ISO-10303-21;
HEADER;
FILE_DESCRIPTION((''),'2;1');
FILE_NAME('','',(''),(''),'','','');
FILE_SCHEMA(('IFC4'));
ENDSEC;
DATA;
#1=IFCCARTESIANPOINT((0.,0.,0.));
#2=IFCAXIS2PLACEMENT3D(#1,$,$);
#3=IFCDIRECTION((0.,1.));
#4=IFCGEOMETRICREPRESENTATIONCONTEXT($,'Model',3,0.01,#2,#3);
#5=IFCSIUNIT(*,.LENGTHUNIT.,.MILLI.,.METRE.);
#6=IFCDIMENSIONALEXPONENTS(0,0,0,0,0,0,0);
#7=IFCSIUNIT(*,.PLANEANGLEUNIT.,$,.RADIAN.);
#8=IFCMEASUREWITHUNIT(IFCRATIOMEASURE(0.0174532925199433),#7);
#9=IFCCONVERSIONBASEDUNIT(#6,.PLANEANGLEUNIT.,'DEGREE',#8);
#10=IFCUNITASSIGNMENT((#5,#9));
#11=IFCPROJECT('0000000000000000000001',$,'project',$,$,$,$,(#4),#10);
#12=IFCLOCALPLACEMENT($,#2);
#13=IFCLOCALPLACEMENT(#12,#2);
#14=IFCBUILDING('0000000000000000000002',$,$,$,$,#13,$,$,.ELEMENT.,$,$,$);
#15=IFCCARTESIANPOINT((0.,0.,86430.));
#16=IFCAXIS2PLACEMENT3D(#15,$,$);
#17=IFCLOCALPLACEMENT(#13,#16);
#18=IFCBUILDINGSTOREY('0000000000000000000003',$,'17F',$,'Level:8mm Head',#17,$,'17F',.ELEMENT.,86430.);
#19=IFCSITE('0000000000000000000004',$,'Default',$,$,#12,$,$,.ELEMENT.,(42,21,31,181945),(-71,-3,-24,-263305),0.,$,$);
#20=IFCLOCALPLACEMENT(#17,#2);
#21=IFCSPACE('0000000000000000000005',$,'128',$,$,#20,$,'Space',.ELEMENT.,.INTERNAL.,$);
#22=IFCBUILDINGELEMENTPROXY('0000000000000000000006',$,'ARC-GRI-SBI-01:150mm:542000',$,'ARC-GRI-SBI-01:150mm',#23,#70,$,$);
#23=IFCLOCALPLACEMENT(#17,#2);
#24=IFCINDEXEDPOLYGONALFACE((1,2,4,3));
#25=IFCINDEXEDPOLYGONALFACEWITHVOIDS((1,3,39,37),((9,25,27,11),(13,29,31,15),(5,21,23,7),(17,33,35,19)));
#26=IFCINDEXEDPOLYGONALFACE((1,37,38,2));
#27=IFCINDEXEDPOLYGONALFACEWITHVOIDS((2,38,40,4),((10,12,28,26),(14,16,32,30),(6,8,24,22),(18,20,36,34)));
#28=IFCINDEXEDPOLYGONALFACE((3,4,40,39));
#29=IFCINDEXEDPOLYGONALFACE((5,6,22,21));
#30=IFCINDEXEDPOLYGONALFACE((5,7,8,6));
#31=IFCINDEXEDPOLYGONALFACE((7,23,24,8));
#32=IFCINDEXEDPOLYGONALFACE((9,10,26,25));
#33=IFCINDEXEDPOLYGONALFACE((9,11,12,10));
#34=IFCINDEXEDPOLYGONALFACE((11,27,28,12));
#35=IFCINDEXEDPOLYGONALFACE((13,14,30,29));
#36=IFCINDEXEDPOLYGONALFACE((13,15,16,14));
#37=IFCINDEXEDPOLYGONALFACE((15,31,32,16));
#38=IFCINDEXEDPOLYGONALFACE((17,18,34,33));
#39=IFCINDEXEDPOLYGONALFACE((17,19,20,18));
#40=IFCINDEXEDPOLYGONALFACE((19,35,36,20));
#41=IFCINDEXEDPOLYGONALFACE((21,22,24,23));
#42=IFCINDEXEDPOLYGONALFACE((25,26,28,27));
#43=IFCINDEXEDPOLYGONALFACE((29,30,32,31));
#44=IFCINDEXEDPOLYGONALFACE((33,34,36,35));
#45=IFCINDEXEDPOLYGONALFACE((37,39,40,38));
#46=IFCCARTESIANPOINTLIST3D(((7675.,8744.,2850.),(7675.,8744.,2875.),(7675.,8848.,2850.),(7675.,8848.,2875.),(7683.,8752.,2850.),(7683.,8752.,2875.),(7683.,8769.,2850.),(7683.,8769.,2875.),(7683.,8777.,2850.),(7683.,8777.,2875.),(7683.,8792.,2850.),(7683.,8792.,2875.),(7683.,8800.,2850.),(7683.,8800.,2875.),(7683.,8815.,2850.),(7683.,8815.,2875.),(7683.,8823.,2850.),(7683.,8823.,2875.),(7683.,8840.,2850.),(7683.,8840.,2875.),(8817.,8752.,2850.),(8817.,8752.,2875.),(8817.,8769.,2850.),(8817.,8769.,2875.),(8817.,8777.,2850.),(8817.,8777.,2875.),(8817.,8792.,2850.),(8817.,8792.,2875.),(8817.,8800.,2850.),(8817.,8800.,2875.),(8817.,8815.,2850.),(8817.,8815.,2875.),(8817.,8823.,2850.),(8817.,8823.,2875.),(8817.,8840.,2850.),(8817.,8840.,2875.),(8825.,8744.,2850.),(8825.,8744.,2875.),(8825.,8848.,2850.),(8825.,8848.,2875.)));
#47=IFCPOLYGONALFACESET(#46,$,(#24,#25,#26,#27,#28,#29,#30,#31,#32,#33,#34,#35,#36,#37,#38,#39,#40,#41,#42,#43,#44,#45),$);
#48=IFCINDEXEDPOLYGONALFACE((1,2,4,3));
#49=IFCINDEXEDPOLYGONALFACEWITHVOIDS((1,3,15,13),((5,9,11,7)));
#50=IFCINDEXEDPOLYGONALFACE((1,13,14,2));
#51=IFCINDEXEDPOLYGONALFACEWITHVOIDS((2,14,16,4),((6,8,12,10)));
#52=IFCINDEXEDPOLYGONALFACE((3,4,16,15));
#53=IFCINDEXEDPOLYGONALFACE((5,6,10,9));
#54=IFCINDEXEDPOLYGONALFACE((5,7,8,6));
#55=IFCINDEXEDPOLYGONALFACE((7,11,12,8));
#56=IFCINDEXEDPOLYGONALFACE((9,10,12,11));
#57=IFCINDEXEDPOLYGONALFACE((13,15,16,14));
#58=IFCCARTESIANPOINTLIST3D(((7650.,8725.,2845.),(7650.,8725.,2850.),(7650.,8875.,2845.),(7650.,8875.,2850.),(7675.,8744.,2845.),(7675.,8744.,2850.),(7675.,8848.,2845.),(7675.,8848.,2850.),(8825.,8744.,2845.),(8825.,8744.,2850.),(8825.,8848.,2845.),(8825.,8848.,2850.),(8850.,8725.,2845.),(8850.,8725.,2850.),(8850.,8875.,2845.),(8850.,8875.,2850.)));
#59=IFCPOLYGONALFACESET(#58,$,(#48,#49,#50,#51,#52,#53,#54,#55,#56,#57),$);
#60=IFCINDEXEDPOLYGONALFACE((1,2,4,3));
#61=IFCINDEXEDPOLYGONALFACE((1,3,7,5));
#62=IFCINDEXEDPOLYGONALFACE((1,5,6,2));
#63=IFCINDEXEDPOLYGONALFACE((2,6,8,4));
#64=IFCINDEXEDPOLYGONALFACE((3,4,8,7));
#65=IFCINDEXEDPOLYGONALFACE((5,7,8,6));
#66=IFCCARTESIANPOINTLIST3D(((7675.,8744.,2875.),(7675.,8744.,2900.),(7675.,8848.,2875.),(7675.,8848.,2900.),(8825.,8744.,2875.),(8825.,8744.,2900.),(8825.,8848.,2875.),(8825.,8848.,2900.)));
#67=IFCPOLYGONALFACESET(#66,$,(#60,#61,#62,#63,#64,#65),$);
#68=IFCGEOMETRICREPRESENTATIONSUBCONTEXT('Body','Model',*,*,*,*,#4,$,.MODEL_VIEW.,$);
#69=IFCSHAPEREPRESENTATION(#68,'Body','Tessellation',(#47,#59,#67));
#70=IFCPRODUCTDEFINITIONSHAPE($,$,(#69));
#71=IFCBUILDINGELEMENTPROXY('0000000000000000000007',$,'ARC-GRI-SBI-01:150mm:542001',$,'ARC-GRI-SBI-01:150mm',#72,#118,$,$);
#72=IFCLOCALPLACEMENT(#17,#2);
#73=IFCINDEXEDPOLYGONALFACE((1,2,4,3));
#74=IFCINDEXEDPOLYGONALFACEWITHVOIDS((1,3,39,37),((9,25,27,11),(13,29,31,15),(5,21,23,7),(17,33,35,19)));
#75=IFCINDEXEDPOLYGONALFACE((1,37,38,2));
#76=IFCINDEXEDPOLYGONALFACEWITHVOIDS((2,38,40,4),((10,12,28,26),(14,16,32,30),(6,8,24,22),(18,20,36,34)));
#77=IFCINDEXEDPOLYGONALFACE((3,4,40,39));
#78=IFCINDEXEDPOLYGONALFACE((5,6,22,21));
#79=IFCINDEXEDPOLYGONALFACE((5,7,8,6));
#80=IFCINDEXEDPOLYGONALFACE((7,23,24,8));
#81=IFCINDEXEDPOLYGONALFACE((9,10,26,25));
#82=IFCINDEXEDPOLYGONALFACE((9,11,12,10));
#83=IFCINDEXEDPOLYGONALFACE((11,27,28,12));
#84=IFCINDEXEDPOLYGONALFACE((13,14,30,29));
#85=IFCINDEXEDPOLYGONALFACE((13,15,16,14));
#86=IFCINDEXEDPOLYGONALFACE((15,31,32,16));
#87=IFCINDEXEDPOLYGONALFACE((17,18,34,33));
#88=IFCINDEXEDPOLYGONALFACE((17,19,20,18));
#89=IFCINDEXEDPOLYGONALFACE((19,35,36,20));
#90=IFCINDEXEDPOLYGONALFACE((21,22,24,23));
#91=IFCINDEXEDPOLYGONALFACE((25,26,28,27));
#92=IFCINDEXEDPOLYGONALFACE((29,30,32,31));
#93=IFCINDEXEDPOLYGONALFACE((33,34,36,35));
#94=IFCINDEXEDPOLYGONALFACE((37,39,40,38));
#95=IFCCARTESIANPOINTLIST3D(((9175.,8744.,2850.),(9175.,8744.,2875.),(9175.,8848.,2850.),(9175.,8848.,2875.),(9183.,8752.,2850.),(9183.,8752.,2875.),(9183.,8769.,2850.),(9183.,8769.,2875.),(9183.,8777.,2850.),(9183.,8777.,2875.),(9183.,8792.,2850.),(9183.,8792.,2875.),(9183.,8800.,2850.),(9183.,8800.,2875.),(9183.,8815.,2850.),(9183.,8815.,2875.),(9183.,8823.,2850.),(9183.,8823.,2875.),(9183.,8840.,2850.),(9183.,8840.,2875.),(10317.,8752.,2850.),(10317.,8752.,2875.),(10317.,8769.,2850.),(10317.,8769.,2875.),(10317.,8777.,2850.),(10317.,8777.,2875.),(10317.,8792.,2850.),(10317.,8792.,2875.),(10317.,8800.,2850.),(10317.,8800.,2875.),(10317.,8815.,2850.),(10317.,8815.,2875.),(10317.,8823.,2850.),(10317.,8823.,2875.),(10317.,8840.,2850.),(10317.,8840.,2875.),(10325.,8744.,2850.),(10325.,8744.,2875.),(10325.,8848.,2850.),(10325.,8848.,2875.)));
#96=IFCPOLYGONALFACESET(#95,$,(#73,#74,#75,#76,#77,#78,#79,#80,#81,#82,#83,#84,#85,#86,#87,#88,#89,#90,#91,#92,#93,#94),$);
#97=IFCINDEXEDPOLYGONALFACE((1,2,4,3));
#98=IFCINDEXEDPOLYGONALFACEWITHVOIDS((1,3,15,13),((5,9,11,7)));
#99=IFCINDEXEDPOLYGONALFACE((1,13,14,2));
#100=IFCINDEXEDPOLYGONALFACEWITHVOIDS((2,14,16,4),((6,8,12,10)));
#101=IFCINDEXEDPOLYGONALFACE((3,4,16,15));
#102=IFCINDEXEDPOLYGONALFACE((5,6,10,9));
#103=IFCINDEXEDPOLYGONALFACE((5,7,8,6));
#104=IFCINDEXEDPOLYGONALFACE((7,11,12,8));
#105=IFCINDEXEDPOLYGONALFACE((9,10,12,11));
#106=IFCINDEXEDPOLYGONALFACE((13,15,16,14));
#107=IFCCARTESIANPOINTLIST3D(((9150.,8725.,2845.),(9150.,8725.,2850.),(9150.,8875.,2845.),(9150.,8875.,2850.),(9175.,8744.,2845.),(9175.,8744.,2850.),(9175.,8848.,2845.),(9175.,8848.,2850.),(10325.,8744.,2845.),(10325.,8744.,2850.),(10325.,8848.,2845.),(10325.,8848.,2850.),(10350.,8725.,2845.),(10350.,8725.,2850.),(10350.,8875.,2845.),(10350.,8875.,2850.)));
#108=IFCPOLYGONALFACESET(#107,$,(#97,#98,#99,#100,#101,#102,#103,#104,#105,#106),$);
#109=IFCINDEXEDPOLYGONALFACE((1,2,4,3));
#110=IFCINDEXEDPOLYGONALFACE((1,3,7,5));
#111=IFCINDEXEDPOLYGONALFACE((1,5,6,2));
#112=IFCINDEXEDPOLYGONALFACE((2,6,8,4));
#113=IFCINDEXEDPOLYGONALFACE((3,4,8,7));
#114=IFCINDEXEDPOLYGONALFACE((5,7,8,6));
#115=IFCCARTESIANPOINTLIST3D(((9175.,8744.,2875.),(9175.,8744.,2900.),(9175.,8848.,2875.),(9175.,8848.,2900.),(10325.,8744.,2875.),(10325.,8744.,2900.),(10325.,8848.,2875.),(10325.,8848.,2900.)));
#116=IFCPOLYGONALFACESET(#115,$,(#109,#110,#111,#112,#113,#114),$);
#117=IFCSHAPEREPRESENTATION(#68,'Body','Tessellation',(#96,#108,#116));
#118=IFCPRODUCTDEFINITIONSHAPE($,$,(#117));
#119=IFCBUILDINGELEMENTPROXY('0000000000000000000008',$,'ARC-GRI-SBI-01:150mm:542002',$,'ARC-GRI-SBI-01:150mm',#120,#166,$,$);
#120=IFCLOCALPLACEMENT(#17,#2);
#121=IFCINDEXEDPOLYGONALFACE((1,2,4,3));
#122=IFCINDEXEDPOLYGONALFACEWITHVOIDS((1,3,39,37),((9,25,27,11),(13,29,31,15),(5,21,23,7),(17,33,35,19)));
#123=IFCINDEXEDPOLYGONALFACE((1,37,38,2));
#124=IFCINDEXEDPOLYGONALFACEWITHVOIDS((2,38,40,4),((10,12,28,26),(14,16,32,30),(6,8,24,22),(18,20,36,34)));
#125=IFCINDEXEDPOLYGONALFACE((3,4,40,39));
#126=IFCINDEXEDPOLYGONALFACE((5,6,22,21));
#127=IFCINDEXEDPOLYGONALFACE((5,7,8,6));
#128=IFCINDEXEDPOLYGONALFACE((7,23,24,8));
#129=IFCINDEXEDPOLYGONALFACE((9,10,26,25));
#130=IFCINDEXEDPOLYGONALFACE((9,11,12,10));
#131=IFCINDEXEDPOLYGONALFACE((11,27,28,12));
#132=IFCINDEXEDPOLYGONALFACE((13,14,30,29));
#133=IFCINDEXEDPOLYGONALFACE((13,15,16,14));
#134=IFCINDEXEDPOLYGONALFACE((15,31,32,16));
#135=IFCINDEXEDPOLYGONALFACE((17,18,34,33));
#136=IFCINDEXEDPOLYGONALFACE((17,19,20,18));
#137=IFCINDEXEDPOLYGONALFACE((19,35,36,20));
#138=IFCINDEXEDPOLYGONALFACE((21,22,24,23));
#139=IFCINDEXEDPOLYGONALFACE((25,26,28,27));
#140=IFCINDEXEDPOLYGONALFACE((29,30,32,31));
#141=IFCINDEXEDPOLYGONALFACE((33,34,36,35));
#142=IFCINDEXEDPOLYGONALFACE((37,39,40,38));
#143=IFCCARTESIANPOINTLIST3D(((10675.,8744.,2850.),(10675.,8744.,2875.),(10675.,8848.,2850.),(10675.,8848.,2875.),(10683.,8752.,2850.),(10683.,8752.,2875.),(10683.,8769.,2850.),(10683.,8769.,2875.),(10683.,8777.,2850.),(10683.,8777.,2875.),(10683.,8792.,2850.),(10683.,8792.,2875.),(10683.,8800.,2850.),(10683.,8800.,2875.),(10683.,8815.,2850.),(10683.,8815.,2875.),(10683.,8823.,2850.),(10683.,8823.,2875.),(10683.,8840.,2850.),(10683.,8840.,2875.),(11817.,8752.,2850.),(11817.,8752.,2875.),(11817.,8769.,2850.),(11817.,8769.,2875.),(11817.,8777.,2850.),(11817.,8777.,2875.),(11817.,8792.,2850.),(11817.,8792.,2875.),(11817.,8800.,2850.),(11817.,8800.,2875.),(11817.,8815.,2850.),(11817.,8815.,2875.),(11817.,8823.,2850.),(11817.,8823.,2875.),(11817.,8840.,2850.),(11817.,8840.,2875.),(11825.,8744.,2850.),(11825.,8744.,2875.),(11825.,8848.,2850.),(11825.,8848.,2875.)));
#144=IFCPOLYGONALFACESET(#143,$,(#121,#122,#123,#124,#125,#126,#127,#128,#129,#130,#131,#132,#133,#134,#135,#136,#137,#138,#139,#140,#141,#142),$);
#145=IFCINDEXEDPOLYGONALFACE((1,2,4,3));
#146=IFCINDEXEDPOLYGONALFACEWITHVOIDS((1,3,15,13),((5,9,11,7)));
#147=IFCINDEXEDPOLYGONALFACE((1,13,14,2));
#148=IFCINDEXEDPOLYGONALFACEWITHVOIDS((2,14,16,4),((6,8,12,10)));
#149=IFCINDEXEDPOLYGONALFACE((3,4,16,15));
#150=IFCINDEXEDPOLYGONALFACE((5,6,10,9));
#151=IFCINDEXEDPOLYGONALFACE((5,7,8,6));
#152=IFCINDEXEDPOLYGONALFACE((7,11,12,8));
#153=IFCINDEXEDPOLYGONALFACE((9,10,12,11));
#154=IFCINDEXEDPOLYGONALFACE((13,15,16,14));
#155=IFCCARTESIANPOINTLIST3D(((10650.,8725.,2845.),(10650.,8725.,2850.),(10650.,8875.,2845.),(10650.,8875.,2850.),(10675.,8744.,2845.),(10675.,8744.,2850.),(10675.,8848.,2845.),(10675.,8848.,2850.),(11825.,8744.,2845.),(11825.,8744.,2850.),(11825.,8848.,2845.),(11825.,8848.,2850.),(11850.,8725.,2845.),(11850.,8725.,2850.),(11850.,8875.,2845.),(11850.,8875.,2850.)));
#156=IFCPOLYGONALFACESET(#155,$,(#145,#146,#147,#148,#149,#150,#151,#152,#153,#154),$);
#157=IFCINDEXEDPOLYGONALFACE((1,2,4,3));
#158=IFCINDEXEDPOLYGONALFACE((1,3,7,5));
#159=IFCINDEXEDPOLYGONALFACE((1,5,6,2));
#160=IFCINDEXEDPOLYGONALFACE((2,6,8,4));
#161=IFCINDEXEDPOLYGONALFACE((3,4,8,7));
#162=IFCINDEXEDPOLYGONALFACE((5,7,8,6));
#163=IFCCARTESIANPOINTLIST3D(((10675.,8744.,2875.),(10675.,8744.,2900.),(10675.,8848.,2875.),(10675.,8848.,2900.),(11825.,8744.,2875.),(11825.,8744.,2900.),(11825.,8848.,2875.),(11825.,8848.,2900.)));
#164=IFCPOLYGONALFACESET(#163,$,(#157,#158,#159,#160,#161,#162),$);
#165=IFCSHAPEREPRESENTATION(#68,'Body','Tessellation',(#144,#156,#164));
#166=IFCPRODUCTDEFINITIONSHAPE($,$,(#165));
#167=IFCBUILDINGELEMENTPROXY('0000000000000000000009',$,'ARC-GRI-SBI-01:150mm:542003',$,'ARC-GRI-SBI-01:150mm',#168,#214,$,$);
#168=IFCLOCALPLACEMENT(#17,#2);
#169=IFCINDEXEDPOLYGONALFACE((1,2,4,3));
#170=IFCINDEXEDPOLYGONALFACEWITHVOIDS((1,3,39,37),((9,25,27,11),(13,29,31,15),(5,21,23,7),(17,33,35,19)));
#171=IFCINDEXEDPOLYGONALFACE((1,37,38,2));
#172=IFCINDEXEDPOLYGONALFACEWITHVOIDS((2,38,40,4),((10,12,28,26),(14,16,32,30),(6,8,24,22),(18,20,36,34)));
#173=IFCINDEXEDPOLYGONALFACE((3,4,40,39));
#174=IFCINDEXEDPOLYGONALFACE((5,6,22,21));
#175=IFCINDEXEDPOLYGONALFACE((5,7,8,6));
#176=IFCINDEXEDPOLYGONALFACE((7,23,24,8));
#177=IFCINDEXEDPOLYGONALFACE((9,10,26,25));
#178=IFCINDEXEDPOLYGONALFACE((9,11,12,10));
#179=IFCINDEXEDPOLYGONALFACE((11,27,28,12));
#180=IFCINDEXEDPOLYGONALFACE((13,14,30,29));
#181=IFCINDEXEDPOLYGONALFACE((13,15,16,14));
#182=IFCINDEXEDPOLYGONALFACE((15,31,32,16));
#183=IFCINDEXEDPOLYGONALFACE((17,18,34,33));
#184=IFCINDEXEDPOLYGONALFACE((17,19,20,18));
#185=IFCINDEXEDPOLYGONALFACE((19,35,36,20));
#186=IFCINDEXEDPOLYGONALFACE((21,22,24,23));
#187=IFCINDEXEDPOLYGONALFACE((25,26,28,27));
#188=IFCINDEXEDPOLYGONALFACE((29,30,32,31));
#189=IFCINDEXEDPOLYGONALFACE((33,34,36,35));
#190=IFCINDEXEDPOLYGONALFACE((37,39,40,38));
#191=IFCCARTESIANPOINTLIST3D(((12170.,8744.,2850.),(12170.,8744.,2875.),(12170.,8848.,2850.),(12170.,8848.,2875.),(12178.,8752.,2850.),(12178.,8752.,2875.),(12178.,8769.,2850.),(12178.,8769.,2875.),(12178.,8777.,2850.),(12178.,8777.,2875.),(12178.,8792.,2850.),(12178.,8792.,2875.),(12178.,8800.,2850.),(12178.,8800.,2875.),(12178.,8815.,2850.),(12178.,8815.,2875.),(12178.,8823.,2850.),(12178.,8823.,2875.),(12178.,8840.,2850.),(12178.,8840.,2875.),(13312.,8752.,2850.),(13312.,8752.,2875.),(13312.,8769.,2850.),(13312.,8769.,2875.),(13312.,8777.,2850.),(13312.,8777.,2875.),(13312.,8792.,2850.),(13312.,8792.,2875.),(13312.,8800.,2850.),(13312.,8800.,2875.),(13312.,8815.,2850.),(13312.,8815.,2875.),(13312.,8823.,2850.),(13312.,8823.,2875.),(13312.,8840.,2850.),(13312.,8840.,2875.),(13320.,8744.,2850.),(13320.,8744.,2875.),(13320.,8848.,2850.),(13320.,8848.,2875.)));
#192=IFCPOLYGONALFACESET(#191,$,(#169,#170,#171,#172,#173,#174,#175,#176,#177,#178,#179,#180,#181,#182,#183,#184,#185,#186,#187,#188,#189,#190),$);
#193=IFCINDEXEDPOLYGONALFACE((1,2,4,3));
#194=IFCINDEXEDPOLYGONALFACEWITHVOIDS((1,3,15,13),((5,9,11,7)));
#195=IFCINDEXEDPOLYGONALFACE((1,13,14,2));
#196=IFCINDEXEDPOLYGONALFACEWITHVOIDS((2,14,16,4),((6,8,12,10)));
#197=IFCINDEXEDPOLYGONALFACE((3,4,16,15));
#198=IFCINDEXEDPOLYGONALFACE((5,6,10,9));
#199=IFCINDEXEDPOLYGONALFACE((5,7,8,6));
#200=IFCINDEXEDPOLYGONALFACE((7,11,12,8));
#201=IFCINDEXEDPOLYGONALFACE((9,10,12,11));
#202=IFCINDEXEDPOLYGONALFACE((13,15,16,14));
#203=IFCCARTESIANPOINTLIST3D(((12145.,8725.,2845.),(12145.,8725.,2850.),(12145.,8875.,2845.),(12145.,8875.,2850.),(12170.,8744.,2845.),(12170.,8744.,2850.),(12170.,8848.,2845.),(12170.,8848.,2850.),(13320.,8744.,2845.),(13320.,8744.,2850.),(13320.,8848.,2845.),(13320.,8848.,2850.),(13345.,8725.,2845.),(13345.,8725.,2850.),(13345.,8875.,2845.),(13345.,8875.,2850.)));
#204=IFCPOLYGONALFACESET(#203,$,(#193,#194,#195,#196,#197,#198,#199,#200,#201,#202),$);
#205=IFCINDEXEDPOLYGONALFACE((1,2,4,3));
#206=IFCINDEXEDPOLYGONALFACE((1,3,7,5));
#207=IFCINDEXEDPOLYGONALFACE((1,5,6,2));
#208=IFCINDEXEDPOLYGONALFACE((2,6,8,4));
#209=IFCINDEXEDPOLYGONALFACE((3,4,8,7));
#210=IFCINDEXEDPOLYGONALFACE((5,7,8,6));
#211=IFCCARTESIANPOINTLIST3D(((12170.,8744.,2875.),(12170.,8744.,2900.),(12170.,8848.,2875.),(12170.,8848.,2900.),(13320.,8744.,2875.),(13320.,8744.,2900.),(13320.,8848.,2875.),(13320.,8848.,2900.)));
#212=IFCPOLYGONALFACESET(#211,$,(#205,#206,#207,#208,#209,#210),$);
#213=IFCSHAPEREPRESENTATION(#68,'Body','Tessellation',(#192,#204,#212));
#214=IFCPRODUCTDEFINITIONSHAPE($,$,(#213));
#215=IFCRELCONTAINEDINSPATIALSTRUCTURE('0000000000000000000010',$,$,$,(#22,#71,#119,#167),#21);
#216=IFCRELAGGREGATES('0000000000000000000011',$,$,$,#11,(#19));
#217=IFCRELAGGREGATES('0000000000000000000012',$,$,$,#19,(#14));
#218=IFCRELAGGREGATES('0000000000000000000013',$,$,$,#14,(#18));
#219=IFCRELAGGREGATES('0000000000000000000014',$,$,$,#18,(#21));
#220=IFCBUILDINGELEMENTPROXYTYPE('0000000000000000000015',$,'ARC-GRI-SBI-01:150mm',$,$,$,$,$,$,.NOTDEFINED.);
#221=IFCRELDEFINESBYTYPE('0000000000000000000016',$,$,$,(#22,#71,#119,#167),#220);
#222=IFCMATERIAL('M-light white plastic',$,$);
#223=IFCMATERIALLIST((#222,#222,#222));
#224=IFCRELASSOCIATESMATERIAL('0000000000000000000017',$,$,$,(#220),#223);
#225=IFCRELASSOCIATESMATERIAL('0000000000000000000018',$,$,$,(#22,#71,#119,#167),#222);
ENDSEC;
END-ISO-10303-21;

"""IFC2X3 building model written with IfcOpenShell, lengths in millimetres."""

from ifc_helpers import new_model, entity, si_unit, converted_unit, direction, frame, origin, origin_2d_with_axis, place, context, subcontext, project, spatial, polyline, rectangle, outline, extrude, source, transform, mapped, material, material_list, type_object, type_shapes, element, save


model = new_model("IFC2X3")

# Units and contexts
model_context = context("Model", 3, precision=0.01, world=origin(), true_north=direction((0.0, 1.0)))
body_context = subcontext(model_context, "Body", "Model", "MODEL_VIEW")
ifc_project = project(units=[si_unit("LENGTHUNIT", "METRE", prefix="MILLI"), converted_unit("PLANEANGLEUNIT", "DEGREE", entity("IfcRatioMeasure", 0.0174532925199433), si_unit("PLANEANGLEUNIT", "RADIAN"), dimensions=[0, 0, 0, 0, 0, 0, 0])], contexts=[model_context])

# Site, building, storey
site_placement = place(None, origin())
site = spatial("IfcSite", under=ifc_project, at=site_placement, Name="Default", CompositionType="ELEMENT", RefLatitude=(42, 21, 31, 181945), RefLongitude=(-71, -3, -24, -263305), RefElevation=0.0)
building_placement = place(site_placement, origin())
building = spatial("IfcBuilding", under=site, at=building_placement, CompositionType="ELEMENT")
storey_placement = place(building_placement, frame((0.0, 0.0, 86430.0)))
storey = spatial("IfcBuildingStorey", under=building, at=storey_placement, Name="17F", ObjectType="Level:8mm Head", LongName="17F", CompositionType="ELEMENT", Elevation=86430.0)

# Shared definitions
space_placement = place(storey_placement, origin())
space = spatial("IfcSpace", under=storey, at=space_placement, Name="128", LongName="Space", CompositionType="ELEMENT", InteriorOrExteriorSpace="INTERNAL")

# Building element proxies
ifc_material_1 = material(Name="M-light white plastic")
ifc_material_list = material_list([ifc_material_1, ifc_material_1, ifc_material_1])
building_element_proxy_type = type_object("IfcBuildingElementProxyType", Name="ARC-GRI-SBI-01:150mm", PredefinedType="NOTDEFINED", material=ifc_material_list)
shared_shape = source(origin(), body_context, "Body", "SweptSolid", [
    extrude(outline(polyline([(-575.0, -52.0), (575.0, -52.0), (575.0, 52.0), (-575.0, 52.0), (-575.0, -52.0)]), holes=[polyline([(-567.0, -44.0), (-567.0, -27.0), (567.0, -27.0), (567.0, -44.0), (-567.0, -44.0)]), polyline([(567.0, -4.0), (567.0, -19.0), (-567.0, -19.0), (-567.0, -4.0), (567.0, -4.0)]), polyline([(-567.0, 44.0), (567.0, 44.0), (567.0, 27.0), (-567.0, 27.0), (-567.0, 44.0)]), polyline([(567.0, 4.0), (-567.0, 4.0), (-567.0, 19.0), (567.0, 19.0), (567.0, 4.0)])]), frame((425.0, 4.0, 4000.0), z_axis=(0.0, 0.0, 1.0), x_axis=(-1.0, 0.0, 0.0)), (0.0, 0.0, 1.0), 25.0),
    extrude(outline(polyline([(-600.0, -75.0), (600.0, -75.0), (600.0, 75.0), (-600.0, 75.0), (-600.0, -75.0)]), holes=[polyline([(-575.0, -56.0), (-575.0, 48.0), (575.0, 48.0), (575.0, -56.0), (-575.0, -56.0)])]), frame((425.0, 0.0, 3995.0), z_axis=(0.0, 0.0, 1.0), x_axis=(-1.0, 0.0, 0.0)), (0.0, 0.0, 1.0), 5.0),
    extrude(rectangle(XDim=1150.0, YDim=104.0, at=origin_2d_with_axis()), frame((425.0, 4.0, 4025.0), z_axis=(0.0, 0.0, 1.0), x_axis=(-1.0, 0.0, 0.0)), (0.0, 0.0, 1.0), 25.0),
])
type_shapes(building_element_proxy_type, [shared_shape])
for number, where, z_axis, x_axis, name in (
    (1, (8675.0, 8800.0, -1150.0), (0.0, 0.0, 1.0), (-1.0, 0.0, 0.0), "ARC-GRI-SBI-01:150mm:542000"),
    (2, (10175.0, 8800.0, -1150.0), (0.0, 0.0, 1.0), (-1.0, 0.0, 0.0), "ARC-GRI-SBI-01:150mm:542001"),
    (3, (11675.0, 8800.0, -1150.0), (0.0, 0.0, 1.0), (-1.0, 0.0, 0.0), "ARC-GRI-SBI-01:150mm:542002"),
    (4, (13170.0, 8800.0, -1150.0), (0.0, 0.0, 1.0), (-1.0, 0.0, 0.0), "ARC-GRI-SBI-01:150mm:542003"),
):
    element("IfcBuildingElementProxy", number, at=place(space_placement, frame(where, z_axis=z_axis, x_axis=x_axis)), inside=space, type_object=building_element_proxy_type, material=ifc_material_1, Name=name, ObjectType="ARC-GRI-SBI-01:150mm", context=body_context, shape_type="MappedRepresentation", body=[
        mapped(shared_shape, transform((0.0, 0.0, 0.0), scale=1.0)),
    ])

save(model, "model.ifc")
